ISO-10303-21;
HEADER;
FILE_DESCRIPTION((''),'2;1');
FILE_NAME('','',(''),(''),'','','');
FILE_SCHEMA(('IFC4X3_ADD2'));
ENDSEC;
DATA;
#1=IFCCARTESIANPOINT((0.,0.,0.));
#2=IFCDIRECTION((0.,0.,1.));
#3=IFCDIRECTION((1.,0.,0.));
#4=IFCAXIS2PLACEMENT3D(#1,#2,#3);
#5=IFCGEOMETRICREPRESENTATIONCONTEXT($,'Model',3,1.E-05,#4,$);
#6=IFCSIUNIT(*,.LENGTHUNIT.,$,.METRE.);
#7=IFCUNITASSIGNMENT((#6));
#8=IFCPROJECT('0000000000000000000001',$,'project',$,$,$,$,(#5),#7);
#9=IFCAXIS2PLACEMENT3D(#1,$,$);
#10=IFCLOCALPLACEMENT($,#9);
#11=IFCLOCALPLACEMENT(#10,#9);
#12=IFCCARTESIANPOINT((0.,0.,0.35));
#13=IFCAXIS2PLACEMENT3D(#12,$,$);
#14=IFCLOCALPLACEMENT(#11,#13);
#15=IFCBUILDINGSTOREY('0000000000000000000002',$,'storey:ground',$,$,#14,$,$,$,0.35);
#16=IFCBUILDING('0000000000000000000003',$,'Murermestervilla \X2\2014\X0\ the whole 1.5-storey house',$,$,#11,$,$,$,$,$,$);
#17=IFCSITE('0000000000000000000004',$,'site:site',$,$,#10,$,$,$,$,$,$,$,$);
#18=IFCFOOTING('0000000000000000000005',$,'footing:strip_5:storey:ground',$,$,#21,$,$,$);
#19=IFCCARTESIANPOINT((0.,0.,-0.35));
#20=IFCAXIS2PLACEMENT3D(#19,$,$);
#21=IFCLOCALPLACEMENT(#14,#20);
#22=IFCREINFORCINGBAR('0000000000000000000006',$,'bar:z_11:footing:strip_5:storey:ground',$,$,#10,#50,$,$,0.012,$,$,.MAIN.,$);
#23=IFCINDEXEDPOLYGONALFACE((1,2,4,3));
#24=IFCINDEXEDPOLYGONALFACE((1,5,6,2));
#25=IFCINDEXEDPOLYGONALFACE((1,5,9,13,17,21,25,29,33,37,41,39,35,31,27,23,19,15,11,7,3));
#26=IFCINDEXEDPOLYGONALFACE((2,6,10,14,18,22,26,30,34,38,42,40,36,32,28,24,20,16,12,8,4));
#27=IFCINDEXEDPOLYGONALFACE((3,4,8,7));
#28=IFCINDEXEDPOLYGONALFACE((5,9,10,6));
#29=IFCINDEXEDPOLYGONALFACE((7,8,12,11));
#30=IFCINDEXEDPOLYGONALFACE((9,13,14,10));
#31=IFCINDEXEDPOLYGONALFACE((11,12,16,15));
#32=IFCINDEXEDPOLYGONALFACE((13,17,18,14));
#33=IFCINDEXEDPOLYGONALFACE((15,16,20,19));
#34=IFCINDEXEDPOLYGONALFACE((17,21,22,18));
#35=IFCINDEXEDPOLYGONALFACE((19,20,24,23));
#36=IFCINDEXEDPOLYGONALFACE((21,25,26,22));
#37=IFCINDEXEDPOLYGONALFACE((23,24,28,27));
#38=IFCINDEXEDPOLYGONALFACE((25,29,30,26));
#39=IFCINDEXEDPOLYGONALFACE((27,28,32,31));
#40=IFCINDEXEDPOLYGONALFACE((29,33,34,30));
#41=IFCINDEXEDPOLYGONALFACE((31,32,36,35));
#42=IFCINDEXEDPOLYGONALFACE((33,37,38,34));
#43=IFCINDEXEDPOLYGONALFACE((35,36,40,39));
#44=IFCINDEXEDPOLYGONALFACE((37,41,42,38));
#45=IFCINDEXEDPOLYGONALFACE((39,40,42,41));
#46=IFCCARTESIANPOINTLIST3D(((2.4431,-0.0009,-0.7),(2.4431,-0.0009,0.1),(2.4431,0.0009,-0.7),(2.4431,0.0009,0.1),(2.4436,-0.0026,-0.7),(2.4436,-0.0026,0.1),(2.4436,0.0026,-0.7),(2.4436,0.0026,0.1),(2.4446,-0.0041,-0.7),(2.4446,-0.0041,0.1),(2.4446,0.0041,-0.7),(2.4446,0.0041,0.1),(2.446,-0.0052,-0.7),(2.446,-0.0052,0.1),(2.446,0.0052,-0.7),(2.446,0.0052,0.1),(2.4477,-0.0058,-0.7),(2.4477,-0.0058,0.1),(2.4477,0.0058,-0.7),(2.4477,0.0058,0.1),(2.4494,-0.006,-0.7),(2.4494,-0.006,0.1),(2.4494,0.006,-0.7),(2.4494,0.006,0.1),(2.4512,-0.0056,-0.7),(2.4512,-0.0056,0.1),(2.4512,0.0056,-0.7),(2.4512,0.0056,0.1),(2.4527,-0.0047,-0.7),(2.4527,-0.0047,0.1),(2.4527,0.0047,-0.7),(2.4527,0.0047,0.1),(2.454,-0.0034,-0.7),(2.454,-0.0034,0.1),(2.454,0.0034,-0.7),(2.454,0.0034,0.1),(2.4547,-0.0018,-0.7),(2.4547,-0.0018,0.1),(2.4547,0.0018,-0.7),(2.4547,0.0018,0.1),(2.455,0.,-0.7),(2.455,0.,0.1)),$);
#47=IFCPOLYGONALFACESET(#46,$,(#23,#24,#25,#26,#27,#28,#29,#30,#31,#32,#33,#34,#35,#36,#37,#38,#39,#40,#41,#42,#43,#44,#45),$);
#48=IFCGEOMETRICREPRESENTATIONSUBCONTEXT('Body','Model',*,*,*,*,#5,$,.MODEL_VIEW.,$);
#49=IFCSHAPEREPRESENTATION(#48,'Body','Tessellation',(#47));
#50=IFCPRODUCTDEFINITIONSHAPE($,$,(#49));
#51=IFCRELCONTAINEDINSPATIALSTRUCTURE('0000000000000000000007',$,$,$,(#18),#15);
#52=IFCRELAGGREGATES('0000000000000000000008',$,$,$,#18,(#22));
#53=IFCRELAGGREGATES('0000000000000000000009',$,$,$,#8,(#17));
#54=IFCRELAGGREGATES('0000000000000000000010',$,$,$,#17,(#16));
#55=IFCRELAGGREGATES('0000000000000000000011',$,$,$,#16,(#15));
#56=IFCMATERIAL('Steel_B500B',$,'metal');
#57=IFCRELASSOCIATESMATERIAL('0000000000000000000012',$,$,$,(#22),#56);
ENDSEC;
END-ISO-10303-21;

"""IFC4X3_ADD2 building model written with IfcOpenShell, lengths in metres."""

from ifc_helpers import new_model, entity, si_unit, frame, origin, origin_with_axes, place, context, subcontext, project, spatial, material, element, aggregate, save


model = new_model("IFC4X3_ADD2")

# Units and contexts
model_context = context("Model", 3, precision=1e-05, world=origin_with_axes())
body_context = subcontext(model_context, "Body", "Model", "MODEL_VIEW")
ifc_project = project(units=[si_unit("LENGTHUNIT", "METRE")], contexts=[model_context])

# Site, building, storey
placement_1 = place(None, origin())
site = spatial("IfcSite", under=ifc_project, at=placement_1, Name="site:site")
building_placement = place(placement_1, origin())
building = spatial("IfcBuilding", under=site, at=building_placement, Name="Murermestervilla — the whole 1.5-storey house")
storey_placement = place(building_placement, frame((0.0, 0.0, 0.35)))
storey = spatial("IfcBuildingStorey", under=building, at=storey_placement, Name="storey:ground", Elevation=0.35)

# Footing, reinforcing bar
placement_2 = place(storey_placement, frame((0.0, 0.0, -0.35)))
ifc_material = material(Name="Steel_B500B", Category="metal")
footing_1 = element("IfcFooting", 1, at=placement_2, inside=storey, Name="footing:strip_5:storey:ground")
reinforcing_bar_1 = element("IfcReinforcingBar", 2, at=placement_1, material=ifc_material, Name="bar:z_11:footing:strip_5:storey:ground", NominalDiameter=0.012, PredefinedType="MAIN", context=body_context, shape_type="AdvancedSweptSolid", body=[
    entity("IfcSweptDiskSolid", entity("IfcPolyline", [entity("IfcCartesianPoint", [2.449, 0.0, -0.7]), entity("IfcCartesianPoint", [2.449, 0.0, 0.1])]), 0.006),
])
aggregate(footing_1, [reinforcing_bar_1])

save(model, "model.ifc")
